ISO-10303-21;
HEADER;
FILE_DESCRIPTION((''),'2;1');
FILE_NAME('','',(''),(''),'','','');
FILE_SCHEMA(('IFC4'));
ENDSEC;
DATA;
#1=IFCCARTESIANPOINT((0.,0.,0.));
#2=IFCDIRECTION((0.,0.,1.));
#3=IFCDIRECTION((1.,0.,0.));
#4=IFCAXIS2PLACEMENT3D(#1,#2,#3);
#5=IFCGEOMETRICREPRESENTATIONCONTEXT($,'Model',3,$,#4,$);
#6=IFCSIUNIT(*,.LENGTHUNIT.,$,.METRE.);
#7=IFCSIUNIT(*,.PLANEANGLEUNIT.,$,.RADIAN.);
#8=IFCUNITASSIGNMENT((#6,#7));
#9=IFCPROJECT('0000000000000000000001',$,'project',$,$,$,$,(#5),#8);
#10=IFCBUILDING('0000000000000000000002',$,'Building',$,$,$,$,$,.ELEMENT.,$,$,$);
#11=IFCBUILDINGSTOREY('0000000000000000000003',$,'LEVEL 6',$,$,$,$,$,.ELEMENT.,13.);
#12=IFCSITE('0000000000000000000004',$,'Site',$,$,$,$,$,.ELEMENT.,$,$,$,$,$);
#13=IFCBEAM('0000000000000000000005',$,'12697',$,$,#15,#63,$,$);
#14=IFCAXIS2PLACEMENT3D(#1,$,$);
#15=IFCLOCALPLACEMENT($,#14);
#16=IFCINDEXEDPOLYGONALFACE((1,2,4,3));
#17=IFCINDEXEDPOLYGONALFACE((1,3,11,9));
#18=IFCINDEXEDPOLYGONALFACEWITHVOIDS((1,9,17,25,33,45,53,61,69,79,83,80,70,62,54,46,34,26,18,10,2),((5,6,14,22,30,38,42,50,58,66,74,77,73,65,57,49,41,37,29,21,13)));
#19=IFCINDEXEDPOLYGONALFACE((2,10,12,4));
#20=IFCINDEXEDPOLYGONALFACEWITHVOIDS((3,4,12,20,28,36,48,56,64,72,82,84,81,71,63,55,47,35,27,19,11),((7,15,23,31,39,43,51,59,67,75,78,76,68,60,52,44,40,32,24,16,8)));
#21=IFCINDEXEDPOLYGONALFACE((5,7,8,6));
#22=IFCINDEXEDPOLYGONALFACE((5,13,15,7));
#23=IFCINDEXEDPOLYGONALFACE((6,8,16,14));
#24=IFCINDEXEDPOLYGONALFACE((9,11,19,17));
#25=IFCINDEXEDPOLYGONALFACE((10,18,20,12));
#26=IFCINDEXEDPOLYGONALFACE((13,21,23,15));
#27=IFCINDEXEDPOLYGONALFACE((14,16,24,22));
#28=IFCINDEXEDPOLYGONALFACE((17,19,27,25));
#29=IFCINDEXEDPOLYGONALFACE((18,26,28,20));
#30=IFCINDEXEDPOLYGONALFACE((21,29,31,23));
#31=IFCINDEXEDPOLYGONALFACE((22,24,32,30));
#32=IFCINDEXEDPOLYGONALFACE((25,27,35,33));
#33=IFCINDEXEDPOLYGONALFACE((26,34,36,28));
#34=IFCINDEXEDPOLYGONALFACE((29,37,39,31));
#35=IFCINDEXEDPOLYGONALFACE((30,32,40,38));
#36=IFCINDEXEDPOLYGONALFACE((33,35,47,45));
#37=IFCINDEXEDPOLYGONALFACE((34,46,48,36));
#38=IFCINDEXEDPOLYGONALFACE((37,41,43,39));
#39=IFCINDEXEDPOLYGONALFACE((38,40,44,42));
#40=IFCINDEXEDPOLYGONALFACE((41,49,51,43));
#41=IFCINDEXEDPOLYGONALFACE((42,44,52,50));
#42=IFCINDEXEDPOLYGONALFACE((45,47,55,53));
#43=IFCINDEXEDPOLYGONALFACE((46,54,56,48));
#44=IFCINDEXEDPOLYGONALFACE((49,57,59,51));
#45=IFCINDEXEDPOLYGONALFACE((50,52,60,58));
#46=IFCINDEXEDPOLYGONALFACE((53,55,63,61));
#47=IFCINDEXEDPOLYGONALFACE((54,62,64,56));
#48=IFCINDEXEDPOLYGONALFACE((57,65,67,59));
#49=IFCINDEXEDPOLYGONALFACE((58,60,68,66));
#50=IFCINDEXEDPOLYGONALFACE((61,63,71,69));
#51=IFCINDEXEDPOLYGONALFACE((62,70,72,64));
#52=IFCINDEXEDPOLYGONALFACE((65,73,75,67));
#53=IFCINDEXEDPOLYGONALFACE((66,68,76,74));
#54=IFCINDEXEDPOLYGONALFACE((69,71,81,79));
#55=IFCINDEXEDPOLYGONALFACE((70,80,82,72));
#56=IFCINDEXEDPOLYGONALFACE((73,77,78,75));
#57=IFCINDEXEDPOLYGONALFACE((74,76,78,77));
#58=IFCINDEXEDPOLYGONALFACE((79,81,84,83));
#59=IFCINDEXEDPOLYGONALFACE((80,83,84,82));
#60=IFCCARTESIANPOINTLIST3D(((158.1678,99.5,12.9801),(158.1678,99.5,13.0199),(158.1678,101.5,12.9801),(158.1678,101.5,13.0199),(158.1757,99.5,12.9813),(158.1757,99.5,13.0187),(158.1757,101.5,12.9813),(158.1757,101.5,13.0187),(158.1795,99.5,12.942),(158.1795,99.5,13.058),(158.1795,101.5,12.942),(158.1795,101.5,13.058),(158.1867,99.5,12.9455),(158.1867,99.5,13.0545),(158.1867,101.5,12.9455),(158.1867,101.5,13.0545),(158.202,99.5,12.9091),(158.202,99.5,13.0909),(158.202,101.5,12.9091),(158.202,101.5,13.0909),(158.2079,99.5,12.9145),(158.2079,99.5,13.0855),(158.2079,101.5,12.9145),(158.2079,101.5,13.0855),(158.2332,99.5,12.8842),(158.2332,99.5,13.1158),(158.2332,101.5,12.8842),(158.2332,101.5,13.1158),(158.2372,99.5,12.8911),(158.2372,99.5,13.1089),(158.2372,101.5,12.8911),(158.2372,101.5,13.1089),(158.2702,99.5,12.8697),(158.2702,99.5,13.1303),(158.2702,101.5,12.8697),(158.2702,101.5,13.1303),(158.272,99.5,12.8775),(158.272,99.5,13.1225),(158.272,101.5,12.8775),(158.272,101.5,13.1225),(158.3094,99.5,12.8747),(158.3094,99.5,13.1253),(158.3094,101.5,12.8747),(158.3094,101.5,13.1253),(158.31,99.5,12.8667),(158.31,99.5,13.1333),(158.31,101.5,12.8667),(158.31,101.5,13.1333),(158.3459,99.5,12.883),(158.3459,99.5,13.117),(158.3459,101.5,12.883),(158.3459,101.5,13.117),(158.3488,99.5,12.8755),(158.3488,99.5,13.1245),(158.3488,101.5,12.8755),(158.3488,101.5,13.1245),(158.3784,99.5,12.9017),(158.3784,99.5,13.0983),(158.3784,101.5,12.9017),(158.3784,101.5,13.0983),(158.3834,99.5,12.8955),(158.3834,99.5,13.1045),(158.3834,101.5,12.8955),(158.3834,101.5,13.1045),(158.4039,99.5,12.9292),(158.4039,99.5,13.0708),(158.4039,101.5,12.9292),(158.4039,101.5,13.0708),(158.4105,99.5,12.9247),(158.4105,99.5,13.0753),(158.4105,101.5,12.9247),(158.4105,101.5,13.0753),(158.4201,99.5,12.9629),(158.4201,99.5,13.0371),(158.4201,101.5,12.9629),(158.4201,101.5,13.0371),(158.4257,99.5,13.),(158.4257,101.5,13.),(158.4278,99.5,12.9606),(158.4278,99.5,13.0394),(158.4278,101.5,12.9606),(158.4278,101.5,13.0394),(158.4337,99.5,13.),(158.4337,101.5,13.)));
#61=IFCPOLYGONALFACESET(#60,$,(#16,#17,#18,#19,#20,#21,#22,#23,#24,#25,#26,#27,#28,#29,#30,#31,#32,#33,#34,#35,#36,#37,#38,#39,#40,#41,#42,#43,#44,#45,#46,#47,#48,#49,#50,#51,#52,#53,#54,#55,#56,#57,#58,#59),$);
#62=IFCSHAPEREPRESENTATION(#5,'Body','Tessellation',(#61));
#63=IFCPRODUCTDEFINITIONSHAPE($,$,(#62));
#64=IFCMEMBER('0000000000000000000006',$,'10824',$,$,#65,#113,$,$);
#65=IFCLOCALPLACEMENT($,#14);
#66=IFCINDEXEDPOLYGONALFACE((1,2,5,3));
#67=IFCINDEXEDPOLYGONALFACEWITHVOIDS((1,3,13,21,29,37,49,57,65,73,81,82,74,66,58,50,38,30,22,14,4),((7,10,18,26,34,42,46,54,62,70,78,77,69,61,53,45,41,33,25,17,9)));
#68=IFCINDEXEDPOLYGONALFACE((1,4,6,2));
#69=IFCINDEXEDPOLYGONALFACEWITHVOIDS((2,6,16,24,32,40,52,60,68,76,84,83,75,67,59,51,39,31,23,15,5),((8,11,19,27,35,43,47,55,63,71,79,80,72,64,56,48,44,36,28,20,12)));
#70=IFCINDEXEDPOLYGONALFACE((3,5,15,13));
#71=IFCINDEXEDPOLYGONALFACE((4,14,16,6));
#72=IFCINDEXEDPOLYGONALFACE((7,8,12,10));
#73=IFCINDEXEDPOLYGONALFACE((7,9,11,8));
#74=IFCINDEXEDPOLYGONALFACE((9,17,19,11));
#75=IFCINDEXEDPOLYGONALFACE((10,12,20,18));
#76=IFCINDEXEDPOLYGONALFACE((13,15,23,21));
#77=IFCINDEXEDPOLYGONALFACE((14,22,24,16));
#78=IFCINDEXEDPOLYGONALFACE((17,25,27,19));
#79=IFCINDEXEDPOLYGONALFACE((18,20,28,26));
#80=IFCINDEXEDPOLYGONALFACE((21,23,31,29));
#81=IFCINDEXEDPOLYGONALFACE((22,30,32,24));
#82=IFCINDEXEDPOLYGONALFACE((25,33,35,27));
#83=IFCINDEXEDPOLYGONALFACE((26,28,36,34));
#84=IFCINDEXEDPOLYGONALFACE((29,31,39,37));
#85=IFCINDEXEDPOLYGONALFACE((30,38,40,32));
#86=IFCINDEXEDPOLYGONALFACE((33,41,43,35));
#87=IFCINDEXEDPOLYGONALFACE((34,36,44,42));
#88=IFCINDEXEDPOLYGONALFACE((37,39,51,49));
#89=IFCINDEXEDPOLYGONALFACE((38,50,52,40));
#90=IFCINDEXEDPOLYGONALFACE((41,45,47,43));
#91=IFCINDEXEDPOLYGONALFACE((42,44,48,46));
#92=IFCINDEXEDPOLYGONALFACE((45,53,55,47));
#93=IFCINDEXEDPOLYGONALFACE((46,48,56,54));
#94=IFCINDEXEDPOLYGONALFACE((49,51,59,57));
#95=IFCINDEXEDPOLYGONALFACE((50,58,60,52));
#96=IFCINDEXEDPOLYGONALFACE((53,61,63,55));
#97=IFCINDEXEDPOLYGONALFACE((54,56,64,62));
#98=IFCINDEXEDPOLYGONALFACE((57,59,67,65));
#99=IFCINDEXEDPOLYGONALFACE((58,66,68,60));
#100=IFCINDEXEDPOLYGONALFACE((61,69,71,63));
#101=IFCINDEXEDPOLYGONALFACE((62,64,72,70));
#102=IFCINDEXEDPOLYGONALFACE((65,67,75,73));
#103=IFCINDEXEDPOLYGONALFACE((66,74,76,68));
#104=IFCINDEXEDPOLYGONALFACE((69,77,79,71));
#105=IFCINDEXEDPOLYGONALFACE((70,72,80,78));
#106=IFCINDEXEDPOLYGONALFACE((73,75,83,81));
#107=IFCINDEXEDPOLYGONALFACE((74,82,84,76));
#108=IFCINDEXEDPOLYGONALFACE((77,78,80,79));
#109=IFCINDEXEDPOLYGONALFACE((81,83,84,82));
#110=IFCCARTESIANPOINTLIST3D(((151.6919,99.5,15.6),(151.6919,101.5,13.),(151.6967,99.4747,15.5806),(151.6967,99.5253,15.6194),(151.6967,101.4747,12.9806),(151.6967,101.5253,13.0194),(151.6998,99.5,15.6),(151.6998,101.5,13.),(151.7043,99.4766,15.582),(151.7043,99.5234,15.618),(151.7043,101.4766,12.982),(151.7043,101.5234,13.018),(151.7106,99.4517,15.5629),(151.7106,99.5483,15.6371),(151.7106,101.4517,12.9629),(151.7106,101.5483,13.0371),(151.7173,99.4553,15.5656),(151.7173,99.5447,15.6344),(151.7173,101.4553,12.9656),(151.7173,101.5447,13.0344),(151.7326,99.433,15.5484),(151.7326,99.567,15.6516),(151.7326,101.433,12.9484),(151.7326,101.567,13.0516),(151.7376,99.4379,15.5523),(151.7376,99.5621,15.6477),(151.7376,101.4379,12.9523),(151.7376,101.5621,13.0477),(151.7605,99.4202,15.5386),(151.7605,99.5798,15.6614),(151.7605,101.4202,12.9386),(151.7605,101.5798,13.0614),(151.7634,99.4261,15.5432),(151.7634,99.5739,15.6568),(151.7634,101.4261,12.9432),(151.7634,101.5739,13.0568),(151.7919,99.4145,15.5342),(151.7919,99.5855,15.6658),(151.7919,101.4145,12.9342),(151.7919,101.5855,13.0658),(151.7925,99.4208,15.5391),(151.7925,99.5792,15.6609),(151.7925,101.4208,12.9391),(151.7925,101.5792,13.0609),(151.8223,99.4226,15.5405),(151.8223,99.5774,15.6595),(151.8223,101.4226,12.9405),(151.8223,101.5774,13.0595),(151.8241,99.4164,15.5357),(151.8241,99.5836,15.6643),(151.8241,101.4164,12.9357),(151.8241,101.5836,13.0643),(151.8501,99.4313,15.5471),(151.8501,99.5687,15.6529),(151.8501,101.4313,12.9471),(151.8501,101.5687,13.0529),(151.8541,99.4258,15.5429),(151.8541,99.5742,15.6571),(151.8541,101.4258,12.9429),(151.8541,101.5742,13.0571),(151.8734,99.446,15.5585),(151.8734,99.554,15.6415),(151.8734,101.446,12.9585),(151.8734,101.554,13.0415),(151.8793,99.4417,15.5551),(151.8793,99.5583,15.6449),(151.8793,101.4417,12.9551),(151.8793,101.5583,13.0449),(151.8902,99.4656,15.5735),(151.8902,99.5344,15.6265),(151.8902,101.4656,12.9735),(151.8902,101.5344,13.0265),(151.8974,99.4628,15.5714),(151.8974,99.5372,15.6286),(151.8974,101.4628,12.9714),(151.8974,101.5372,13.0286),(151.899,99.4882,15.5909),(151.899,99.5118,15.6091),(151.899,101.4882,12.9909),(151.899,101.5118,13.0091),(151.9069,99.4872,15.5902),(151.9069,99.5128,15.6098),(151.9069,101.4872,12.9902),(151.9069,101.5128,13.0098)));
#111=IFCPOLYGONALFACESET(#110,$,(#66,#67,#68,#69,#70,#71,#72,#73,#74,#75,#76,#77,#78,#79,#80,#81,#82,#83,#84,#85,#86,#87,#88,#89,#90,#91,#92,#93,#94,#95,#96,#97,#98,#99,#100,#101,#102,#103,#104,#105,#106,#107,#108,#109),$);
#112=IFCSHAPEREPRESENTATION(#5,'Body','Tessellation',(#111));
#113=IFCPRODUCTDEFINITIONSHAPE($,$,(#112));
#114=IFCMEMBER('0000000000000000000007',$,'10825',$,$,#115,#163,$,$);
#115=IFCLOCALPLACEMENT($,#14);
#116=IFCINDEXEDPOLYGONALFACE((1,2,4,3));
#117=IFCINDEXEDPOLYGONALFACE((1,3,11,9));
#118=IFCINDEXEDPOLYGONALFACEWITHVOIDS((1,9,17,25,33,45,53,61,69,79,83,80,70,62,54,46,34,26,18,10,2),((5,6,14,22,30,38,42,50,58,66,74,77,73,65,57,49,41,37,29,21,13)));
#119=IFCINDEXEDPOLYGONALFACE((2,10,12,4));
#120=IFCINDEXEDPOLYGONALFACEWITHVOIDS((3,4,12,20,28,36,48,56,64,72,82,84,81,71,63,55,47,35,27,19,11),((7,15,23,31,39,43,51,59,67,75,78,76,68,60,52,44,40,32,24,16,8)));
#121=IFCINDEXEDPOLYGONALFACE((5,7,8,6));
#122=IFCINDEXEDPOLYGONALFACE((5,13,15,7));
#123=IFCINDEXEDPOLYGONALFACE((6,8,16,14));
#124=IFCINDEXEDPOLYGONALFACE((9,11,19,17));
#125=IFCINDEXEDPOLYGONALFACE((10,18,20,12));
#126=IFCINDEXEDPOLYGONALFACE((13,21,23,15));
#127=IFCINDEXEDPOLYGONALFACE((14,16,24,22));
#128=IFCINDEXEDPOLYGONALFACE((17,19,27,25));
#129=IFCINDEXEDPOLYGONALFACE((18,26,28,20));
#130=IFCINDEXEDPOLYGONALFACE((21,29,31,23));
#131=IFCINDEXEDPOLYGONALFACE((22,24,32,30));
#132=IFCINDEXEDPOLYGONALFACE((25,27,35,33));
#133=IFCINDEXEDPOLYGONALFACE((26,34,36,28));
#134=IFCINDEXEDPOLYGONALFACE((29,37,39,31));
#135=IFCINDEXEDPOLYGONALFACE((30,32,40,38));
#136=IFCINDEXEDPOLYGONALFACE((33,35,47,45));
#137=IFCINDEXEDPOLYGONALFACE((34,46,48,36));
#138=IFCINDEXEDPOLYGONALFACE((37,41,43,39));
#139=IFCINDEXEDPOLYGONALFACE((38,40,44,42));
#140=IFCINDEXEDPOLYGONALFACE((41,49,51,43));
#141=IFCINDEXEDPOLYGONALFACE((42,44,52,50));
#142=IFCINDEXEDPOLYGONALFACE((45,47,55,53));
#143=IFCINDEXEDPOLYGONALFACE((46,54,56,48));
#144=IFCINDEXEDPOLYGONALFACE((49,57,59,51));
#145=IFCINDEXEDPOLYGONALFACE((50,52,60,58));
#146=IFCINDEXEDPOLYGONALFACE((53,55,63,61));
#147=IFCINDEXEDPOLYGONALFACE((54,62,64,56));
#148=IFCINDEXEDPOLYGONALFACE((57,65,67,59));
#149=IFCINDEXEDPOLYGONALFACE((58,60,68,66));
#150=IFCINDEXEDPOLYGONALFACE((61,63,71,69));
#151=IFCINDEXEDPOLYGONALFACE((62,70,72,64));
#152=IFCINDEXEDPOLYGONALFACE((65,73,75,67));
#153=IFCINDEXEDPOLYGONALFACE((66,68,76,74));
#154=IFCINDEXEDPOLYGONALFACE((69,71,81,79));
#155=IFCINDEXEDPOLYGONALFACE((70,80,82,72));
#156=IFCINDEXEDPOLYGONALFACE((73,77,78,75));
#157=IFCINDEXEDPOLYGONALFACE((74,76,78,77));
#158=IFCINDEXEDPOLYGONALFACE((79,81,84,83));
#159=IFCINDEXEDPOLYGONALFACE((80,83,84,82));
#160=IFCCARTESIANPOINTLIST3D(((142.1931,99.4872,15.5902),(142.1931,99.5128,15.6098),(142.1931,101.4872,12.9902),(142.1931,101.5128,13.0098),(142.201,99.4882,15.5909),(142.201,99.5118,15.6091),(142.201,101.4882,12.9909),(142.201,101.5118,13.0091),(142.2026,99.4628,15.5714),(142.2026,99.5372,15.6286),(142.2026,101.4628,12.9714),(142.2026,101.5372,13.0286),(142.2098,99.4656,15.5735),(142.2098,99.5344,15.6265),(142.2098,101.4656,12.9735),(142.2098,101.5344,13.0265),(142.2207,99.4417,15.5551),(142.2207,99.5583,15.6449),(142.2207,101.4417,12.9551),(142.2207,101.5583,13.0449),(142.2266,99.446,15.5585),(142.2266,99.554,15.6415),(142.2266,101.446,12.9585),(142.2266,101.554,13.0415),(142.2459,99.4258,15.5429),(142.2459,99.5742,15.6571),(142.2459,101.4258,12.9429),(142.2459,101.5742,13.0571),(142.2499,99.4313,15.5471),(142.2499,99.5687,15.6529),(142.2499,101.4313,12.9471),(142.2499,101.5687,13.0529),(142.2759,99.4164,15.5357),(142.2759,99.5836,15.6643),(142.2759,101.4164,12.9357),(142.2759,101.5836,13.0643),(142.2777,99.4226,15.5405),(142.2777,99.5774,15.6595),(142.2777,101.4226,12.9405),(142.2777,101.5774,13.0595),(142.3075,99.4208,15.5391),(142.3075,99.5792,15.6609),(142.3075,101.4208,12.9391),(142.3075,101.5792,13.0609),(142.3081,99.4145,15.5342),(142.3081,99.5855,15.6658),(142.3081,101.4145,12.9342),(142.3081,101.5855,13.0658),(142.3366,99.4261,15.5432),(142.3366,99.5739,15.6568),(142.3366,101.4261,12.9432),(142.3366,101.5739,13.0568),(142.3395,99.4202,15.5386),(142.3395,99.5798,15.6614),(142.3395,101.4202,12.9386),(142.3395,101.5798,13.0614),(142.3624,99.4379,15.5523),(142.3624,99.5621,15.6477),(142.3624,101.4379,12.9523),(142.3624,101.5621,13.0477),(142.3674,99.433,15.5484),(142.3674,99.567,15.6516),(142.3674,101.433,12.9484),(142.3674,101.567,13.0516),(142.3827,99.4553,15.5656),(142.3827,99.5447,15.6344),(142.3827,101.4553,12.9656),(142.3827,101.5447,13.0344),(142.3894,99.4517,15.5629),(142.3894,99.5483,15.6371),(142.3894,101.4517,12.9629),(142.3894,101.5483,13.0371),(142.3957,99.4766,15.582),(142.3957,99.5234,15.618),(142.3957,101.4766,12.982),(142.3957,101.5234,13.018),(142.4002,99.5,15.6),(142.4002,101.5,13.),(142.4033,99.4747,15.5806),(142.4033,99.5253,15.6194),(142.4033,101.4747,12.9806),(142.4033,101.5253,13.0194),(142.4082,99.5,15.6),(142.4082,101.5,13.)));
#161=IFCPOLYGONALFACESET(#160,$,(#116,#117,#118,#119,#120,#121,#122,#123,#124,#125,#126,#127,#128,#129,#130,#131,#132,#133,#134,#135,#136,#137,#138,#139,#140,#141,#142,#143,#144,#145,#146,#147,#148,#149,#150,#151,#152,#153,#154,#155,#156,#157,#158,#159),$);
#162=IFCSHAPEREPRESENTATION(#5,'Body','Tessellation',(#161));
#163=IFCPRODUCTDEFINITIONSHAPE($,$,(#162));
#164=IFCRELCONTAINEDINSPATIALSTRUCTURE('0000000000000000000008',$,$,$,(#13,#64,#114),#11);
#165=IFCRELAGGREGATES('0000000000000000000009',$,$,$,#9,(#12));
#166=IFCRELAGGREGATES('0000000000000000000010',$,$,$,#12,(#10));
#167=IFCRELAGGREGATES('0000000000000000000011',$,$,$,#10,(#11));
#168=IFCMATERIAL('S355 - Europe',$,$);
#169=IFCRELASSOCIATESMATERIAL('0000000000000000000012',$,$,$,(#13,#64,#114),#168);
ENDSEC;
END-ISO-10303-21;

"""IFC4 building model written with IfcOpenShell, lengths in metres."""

from ifc_helpers import new_model, si_unit, frame, origin_with_axes, origin_2d_with_axis, place, context, project, spatial, hollow_circle, extrude, material, material_profile, profile_set, profile_usage, element, save


model = new_model("IFC4")

# Units and contexts
model_context = context("Model", 3, world=origin_with_axes())
ifc_project = project(units=[si_unit("LENGTHUNIT", "METRE"), si_unit("PLANEANGLEUNIT", "RADIAN")], contexts=[model_context])

# Site, building, storey
site = spatial("IfcSite", under=ifc_project, Name="Site", CompositionType="ELEMENT")
building = spatial("IfcBuilding", under=site, Name="Building", CompositionType="ELEMENT")
storey = spatial("IfcBuildingStorey", under=building, Name="LEVEL 6", CompositionType="ELEMENT", Elevation=13.0)

# Shared definitions
ifc_material = material(Name="S355 - Europe")

# Beam
ifc_material_profile_1 = material_profile(ifc_material, hollow_circle(Radius=0.1337, WallThickness=0.008, at=origin_2d_with_axis()))
ifc_profile_set_1 = profile_set([ifc_material_profile_1])
ifc_profile_usage_1 = profile_usage(ifc_profile_set_1, cardinal=10)
beam_1_placement = place(None, frame((158.3, 101.5, 13.0), z_axis=(0.0, -1.0, 0.0), x_axis=(1.0, 0.0, 0.0)))
element("IfcBeam", 1, at=beam_1_placement, inside=storey, material=ifc_profile_usage_1, Name="12697", context=model_context, shape_type="SweptSolid", body=[
    extrude(hollow_circle(Radius=0.1337, WallThickness=0.008, at=origin_2d_with_axis()), origin_with_axes(), (0.0, 0.0, 1.0), 2.0),
])

# Members
ifc_material_profile_2 = material_profile(ifc_material, hollow_circle(Radius=0.1081, WallThickness=0.008, at=origin_2d_with_axis()))
ifc_profile_set_2 = profile_set([ifc_material_profile_2])
ifc_profile_usage_2 = profile_usage(ifc_profile_set_2, cardinal=10)
member_1_placement = place(None, frame((151.8, 99.5, 15.6), z_axis=(0.0, 0.609711, -0.792624), x_axis=(-1.0, 0.0, 0.0)))
element("IfcMember", 2, at=member_1_placement, inside=storey, material=ifc_profile_usage_2, Name="10824", context=model_context, shape_type="SweptSolid", body=[
    extrude(hollow_circle(Radius=0.1081, WallThickness=0.008, at=origin_2d_with_axis()), origin_with_axes(), (0.0, 0.0, 1.0), 3.2802),
])
ifc_material_profile_3 = material_profile(ifc_material, hollow_circle(Radius=0.1081, WallThickness=0.008, at=origin_2d_with_axis()))
ifc_profile_set_3 = profile_set([ifc_material_profile_3])
ifc_profile_usage_3 = profile_usage(ifc_profile_set_3, cardinal=10)
member_2_placement = place(None, frame((142.3, 101.5, 13.0), z_axis=(0.0, -0.609711, 0.792624), x_axis=(1.0, 0.0, 0.0)))
element("IfcMember", 3, at=member_2_placement, inside=storey, material=ifc_profile_usage_3, Name="10825", context=model_context, shape_type="SweptSolid", body=[
    extrude(hollow_circle(Radius=0.1081, WallThickness=0.008, at=origin_2d_with_axis()), origin_with_axes(), (0.0, 0.0, 1.0), 3.2802),
])

save(model, "model.ifc")
